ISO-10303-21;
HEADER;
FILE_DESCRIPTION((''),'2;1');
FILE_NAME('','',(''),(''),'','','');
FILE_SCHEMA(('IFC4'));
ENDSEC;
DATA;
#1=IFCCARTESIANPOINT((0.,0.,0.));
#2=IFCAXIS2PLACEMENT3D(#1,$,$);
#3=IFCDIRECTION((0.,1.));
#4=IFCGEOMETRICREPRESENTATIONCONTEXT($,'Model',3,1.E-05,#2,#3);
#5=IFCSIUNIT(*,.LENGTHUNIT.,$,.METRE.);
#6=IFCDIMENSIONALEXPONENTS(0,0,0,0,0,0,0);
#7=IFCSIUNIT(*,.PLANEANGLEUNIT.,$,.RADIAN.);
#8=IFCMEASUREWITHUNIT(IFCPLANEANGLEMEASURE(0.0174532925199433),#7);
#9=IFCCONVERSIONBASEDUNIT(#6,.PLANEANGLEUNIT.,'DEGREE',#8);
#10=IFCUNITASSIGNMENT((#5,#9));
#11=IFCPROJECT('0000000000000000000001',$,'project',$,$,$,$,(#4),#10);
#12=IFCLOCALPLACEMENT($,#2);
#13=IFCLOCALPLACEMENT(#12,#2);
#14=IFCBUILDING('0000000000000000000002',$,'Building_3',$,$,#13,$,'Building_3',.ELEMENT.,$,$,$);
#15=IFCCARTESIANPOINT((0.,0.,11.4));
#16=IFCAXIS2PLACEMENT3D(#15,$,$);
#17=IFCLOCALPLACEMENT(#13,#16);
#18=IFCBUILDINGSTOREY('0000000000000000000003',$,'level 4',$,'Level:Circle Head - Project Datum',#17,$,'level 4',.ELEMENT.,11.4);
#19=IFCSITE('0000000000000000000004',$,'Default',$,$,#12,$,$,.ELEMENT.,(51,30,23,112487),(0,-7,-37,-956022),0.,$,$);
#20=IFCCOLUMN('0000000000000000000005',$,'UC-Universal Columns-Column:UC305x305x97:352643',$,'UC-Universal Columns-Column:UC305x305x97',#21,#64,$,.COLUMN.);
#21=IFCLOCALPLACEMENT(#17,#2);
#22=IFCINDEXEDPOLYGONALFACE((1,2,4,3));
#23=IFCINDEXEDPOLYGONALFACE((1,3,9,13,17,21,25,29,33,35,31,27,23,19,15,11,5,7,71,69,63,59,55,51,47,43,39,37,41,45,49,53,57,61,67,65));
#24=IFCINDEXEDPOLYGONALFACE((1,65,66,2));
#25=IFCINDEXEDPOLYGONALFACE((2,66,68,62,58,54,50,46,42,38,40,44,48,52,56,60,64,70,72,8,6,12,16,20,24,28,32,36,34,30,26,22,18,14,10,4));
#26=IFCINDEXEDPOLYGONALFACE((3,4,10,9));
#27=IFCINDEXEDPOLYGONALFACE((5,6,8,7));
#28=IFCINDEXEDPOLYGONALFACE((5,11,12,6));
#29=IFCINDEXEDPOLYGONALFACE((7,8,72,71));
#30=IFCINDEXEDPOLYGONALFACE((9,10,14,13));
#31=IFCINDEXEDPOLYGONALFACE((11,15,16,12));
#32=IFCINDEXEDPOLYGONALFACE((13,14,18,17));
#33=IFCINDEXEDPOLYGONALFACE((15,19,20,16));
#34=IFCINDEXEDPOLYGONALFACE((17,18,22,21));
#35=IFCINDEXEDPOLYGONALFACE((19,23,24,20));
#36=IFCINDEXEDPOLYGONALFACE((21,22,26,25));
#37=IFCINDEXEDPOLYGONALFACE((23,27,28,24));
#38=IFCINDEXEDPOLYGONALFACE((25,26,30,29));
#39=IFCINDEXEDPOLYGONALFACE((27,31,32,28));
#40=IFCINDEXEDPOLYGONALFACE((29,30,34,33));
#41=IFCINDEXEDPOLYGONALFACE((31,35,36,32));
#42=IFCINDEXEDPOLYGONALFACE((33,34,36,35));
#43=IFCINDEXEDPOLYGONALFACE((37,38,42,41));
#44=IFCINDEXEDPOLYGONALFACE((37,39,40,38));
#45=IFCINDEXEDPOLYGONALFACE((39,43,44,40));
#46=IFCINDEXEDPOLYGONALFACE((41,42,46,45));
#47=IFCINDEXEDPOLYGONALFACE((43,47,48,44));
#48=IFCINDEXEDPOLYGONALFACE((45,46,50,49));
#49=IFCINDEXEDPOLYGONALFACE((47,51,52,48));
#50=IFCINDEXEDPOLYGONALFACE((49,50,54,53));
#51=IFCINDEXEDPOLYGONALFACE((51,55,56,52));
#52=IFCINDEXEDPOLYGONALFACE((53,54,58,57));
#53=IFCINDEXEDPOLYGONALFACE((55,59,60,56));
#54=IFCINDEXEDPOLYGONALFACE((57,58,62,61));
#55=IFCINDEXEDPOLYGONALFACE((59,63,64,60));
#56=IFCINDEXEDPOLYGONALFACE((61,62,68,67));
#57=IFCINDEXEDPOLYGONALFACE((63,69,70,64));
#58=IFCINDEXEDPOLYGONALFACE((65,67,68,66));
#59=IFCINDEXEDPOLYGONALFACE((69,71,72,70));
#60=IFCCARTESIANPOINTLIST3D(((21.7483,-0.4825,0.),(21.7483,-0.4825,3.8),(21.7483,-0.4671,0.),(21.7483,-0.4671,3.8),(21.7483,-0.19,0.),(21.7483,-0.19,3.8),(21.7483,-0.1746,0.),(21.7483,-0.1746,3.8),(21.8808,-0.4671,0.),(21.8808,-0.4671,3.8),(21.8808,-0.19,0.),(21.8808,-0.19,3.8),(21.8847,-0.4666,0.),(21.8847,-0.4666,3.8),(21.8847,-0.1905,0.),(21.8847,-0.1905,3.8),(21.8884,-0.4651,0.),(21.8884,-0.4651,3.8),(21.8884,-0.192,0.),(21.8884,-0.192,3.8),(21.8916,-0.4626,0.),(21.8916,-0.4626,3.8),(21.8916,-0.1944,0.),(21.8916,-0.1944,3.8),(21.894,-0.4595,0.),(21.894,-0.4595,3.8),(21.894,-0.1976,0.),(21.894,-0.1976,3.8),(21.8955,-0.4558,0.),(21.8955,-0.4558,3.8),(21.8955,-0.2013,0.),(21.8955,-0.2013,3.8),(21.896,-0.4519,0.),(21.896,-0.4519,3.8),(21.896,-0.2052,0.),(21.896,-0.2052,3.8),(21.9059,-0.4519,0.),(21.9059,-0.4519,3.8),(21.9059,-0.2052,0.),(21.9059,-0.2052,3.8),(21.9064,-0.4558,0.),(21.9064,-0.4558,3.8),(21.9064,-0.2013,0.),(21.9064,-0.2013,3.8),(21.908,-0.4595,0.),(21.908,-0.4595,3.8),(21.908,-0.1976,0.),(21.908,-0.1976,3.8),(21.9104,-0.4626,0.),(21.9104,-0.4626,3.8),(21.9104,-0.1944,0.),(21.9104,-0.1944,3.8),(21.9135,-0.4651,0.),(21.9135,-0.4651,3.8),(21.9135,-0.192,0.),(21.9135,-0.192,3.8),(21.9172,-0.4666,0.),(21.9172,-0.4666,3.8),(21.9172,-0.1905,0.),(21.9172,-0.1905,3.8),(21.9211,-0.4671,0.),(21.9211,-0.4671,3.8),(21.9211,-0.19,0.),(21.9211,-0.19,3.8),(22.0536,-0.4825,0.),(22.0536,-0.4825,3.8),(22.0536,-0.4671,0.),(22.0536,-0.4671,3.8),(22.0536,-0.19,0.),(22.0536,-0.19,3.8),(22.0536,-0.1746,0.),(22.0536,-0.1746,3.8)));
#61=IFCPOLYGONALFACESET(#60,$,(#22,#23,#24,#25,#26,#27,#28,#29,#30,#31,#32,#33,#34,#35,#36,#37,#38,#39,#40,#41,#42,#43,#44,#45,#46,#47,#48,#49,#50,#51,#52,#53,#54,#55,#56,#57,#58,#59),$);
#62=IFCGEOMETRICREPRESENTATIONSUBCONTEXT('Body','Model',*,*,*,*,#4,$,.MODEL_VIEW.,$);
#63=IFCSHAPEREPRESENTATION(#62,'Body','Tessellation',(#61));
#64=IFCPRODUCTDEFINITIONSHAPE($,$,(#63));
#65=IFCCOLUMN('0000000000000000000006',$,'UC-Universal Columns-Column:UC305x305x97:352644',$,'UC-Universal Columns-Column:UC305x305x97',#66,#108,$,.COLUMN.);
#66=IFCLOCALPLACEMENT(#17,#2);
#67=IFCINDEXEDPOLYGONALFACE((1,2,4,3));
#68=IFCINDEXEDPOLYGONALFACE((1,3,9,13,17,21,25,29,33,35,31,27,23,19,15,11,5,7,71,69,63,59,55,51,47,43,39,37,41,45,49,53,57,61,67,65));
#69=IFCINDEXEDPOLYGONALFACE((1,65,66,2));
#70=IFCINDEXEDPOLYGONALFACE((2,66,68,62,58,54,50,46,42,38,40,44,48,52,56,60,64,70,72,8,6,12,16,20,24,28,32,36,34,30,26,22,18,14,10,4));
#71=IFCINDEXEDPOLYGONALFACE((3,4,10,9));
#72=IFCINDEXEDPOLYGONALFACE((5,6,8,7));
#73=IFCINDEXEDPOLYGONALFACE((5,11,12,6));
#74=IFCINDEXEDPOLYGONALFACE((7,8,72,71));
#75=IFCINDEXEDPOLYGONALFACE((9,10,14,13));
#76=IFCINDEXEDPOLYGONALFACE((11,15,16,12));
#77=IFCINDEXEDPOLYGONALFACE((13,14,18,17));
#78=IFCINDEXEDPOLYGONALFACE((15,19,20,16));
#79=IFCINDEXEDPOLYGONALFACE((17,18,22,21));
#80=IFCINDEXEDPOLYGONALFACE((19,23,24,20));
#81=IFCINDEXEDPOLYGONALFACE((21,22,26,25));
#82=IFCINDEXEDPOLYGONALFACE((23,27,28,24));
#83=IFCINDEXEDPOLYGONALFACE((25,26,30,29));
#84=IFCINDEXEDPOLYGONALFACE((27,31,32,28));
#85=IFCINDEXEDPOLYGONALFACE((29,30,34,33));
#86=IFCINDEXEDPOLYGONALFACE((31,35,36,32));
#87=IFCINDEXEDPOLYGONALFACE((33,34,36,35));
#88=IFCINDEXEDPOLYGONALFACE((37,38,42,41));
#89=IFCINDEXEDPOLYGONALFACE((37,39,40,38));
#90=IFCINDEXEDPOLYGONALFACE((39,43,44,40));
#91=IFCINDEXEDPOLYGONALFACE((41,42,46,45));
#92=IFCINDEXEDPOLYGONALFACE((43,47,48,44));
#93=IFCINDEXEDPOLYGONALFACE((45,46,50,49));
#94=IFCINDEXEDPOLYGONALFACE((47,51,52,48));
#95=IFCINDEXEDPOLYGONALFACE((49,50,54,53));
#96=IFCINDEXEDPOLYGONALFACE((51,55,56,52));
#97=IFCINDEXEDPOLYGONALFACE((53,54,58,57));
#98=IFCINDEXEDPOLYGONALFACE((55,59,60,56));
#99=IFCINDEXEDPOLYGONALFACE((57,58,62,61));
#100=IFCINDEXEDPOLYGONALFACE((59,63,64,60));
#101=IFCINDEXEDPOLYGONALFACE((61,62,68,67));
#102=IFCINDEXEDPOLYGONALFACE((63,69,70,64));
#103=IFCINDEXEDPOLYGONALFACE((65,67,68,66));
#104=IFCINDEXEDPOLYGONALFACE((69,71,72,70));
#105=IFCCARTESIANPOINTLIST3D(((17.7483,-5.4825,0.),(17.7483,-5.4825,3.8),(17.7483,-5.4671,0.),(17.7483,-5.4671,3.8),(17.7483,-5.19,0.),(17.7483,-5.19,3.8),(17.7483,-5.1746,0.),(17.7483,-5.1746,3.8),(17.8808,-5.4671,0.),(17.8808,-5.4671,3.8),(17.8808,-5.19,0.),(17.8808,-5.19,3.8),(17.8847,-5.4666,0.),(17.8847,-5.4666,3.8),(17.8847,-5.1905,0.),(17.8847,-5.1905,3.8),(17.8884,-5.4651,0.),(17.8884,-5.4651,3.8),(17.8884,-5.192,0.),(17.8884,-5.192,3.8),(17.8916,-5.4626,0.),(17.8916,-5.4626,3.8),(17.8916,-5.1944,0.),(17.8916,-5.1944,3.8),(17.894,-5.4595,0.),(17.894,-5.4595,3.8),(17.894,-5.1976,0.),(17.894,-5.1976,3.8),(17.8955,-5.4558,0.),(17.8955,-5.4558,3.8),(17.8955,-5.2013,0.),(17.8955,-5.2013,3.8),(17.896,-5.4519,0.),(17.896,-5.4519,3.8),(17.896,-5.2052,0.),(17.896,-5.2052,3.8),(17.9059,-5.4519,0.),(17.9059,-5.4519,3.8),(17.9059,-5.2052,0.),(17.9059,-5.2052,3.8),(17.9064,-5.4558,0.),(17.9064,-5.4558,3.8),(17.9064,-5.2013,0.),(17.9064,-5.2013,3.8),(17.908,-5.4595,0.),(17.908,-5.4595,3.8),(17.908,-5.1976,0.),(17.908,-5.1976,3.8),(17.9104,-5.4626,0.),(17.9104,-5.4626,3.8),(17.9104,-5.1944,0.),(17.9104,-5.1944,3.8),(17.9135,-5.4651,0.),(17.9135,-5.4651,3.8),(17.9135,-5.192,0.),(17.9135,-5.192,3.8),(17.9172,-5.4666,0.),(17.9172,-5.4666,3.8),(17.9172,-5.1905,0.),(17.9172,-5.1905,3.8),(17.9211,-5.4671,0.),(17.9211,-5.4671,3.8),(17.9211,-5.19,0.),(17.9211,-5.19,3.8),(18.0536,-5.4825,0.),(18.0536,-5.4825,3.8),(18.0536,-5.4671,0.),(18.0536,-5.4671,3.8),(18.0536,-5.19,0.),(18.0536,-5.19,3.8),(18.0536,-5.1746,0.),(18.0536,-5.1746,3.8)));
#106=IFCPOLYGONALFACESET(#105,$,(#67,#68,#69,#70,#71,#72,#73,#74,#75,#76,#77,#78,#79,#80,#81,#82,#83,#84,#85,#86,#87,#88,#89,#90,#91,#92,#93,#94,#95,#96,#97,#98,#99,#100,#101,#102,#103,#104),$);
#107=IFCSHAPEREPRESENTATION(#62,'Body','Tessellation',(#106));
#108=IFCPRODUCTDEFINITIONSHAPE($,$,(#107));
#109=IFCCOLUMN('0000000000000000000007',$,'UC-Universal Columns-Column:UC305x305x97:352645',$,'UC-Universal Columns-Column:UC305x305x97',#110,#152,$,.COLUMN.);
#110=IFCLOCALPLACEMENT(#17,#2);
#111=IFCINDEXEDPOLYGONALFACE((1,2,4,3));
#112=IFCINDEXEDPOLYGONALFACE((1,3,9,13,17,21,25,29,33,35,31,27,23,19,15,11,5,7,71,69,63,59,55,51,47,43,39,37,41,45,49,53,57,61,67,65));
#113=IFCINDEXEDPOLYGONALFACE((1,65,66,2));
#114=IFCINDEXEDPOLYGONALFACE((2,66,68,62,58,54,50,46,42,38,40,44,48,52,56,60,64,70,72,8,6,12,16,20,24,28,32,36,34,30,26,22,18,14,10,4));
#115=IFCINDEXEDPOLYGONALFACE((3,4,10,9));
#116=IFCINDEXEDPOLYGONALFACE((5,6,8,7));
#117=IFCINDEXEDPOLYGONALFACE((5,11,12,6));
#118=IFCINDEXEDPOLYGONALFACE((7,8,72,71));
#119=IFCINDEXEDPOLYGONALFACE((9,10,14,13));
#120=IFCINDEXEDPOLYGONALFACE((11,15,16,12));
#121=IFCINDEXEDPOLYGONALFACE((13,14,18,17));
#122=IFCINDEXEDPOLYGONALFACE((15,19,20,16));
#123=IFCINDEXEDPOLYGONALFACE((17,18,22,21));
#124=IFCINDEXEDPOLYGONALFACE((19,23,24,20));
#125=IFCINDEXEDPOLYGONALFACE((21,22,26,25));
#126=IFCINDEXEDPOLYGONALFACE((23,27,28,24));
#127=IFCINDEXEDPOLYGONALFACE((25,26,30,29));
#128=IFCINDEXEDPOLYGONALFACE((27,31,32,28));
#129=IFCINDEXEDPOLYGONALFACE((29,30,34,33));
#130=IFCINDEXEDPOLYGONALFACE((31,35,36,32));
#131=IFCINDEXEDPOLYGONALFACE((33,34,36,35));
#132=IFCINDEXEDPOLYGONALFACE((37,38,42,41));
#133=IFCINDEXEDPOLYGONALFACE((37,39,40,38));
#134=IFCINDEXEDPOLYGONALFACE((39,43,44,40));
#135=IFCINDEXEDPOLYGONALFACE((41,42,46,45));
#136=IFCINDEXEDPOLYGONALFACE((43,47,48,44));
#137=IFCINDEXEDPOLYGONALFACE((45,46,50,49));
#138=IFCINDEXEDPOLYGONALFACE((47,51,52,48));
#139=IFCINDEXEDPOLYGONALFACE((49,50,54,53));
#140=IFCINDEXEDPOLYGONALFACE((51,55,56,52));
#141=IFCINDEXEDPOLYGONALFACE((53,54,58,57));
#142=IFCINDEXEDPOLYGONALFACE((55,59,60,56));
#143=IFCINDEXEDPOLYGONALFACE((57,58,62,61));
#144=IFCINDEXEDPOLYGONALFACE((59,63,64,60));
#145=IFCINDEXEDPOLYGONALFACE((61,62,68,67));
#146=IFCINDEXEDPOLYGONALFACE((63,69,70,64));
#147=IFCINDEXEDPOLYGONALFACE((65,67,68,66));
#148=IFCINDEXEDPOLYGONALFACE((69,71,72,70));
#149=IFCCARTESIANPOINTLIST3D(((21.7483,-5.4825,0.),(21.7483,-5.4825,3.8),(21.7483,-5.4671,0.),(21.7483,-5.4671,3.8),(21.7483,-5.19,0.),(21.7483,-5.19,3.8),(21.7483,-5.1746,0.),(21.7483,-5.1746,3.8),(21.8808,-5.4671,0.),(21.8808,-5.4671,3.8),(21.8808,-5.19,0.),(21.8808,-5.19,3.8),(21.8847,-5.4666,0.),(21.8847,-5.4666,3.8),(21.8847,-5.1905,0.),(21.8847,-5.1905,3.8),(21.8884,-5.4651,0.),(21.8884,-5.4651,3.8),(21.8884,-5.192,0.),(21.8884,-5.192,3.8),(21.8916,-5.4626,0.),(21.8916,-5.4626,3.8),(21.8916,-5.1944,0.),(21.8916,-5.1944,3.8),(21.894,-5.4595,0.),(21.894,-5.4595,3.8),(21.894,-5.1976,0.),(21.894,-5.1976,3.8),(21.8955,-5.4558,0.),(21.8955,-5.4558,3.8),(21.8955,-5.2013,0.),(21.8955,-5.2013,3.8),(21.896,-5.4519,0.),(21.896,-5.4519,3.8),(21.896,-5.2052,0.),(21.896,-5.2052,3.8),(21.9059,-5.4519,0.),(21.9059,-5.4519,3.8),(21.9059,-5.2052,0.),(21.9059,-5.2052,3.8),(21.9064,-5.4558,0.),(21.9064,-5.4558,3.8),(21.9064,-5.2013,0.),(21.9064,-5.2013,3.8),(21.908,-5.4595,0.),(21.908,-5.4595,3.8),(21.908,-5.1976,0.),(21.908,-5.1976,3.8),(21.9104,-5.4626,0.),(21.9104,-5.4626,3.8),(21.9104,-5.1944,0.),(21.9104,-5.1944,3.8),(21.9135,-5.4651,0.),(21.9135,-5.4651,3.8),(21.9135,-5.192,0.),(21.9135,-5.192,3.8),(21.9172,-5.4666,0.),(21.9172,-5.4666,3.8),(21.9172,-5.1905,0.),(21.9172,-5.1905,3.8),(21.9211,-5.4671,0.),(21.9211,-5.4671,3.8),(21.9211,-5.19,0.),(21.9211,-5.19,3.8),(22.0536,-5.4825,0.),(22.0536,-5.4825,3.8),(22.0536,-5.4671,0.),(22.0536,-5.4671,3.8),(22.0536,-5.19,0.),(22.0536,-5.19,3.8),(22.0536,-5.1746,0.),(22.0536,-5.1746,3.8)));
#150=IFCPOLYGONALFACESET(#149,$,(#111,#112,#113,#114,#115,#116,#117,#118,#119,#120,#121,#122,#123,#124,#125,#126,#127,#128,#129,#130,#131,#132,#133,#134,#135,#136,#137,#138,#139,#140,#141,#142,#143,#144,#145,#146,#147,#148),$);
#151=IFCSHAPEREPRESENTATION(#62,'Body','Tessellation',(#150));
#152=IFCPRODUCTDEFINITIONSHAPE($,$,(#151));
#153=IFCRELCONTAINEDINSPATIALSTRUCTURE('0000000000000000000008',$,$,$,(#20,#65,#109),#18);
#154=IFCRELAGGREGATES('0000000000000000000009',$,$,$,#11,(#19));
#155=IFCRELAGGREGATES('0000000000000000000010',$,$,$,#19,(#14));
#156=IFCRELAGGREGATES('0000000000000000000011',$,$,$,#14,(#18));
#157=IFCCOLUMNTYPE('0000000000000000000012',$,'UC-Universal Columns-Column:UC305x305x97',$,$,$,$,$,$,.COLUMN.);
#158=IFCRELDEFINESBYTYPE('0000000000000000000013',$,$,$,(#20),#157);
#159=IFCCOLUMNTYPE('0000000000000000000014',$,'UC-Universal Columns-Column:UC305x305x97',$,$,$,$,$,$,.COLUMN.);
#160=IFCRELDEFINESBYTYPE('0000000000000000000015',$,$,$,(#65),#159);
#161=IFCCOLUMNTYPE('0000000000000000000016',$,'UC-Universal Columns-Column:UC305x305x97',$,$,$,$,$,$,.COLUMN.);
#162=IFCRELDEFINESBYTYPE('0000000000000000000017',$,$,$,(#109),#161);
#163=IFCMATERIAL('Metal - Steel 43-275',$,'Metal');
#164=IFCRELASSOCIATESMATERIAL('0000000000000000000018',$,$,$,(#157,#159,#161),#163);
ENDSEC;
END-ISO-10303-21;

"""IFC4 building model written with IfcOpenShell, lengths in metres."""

from ifc_helpers import new_model, entity, si_unit, converted_unit, direction, frame, frame_2d, origin, place, context, subcontext, project, spatial, i_section, extrude, source, transform, mapped, material, material_profile, profile_set, type_object, type_shapes, element, save


model = new_model("IFC4")

# Units and contexts
model_context = context("Model", 3, precision=1e-05, world=origin(), true_north=direction((0.0, 1.0)))
body_context = subcontext(model_context, "Body", "Model", "MODEL_VIEW")
ifc_project = project(units=[si_unit("LENGTHUNIT", "METRE"), converted_unit("PLANEANGLEUNIT", "DEGREE", entity("IfcPlaneAngleMeasure", 0.0174532925199433), si_unit("PLANEANGLEUNIT", "RADIAN"), dimensions=[0, 0, 0, 0, 0, 0, 0])], contexts=[model_context])

# Site, building, storey
site_placement = place(None, origin())
site = spatial("IfcSite", under=ifc_project, at=site_placement, Name="Default", CompositionType="ELEMENT", RefLatitude=(51, 30, 23, 112487), RefLongitude=(0, -7, -37, -956022), RefElevation=0.0)
building_placement = place(site_placement, origin())
building = spatial("IfcBuilding", under=site, at=building_placement, Name="Building_3", LongName="Building_3", CompositionType="ELEMENT")
storey_placement = place(building_placement, frame((0.0, 0.0, 11.4)))
storey = spatial("IfcBuildingStorey", under=building, at=storey_placement, Name="level 4", ObjectType="Level:Circle Head - Project Datum", LongName="level 4", CompositionType="ELEMENT", Elevation=11.4)

# Columns
ifc_material_1 = material(Name="Metal - Steel 43-275", Category="Metal")
ifc_material_profile_1 = material_profile(ifc_material_1, i_section(OverallWidth=0.3053, OverallDepth=0.3079, WebThickness=0.0099, FlangeThickness=0.0154, FilletRadius=0.0152, at=frame_2d((0.0, 0.0), x_axis=(1.0, 0.0))), Name="UC305x305x97")
ifc_profile_set_1 = profile_set([ifc_material_profile_1], Name="UC305x305x97")
column_type_1 = type_object("IfcColumnType", Name="UC-Universal Columns-Column:UC305x305x97", PredefinedType="COLUMN", material=ifc_profile_set_1)
shared_shape_1 = source(origin(), body_context, "Body", "SweptSolid", [
    extrude(i_section(OverallWidth=0.3053, OverallDepth=0.3079, WebThickness=0.0099, FlangeThickness=0.0154, FilletRadius=0.0152, at=frame_2d((0.0, 0.0), x_axis=(1.0, 0.0))), frame((21.901, -0.3285, 11.4), z_axis=(0.0, 0.0, 1.0), x_axis=(-1.0, 0.0, 0.0)), (0.0, 0.0, 1.0), 3.8),
])
type_shapes(column_type_1, [shared_shape_1])
column_1_placement = place(storey_placement, frame((0.0, 0.0, -11.4)))
element("IfcColumn", 1, at=column_1_placement, inside=storey, type_object=column_type_1, Name="UC-Universal Columns-Column:UC305x305x97:352643", ObjectType="UC-Universal Columns-Column:UC305x305x97", PredefinedType="COLUMN", context=body_context, shape_type="MappedRepresentation", body=[
    mapped(shared_shape_1, transform((0.0, 0.0, 0.0), scale=1.0)),
])
column_type_2 = type_object("IfcColumnType", Name="UC-Universal Columns-Column:UC305x305x97", PredefinedType="COLUMN", material=ifc_profile_set_1)
shared_shape_2 = source(origin(), body_context, "Body", "SweptSolid", [
    extrude(i_section(OverallWidth=0.3053, OverallDepth=0.3079, WebThickness=0.0099, FlangeThickness=0.0154, FilletRadius=0.0152, at=frame_2d((0.0, 0.0), x_axis=(1.0, 0.0))), frame((17.901, -5.3285, 11.4), z_axis=(0.0, 0.0, 1.0), x_axis=(-1.0, 0.0, 0.0)), (0.0, 0.0, 1.0), 3.8),
])
type_shapes(column_type_2, [shared_shape_2])
column_2_placement = place(storey_placement, frame((0.0, 0.0, -11.4)))
element("IfcColumn", 2, at=column_2_placement, inside=storey, type_object=column_type_2, Name="UC-Universal Columns-Column:UC305x305x97:352644", ObjectType="UC-Universal Columns-Column:UC305x305x97", PredefinedType="COLUMN", context=body_context, shape_type="MappedRepresentation", body=[
    mapped(shared_shape_2, transform((0.0, 0.0, 0.0), scale=1.0)),
])
column_type_3 = type_object("IfcColumnType", Name="UC-Universal Columns-Column:UC305x305x97", PredefinedType="COLUMN", material=ifc_profile_set_1)
shared_shape_3 = source(origin(), body_context, "Body", "SweptSolid", [
    extrude(i_section(OverallWidth=0.3053, OverallDepth=0.3079, WebThickness=0.0099, FlangeThickness=0.0154, FilletRadius=0.0152, at=frame_2d((0.0, 0.0), x_axis=(1.0, 0.0))), frame((21.901, -5.3285, 11.4), z_axis=(0.0, 0.0, 1.0), x_axis=(-1.0, 0.0, 0.0)), (0.0, 0.0, 1.0), 3.8),
])
type_shapes(column_type_3, [shared_shape_3])
column_3_placement = place(storey_placement, frame((0.0, 0.0, -11.4)))
element("IfcColumn", 3, at=column_3_placement, inside=storey, type_object=column_type_3, Name="UC-Universal Columns-Column:UC305x305x97:352645", ObjectType="UC-Universal Columns-Column:UC305x305x97", PredefinedType="COLUMN", context=body_context, shape_type="MappedRepresentation", body=[
    mapped(shared_shape_3, transform((0.0, 0.0, 0.0), scale=1.0)),
])

save(model, "model.ifc")
